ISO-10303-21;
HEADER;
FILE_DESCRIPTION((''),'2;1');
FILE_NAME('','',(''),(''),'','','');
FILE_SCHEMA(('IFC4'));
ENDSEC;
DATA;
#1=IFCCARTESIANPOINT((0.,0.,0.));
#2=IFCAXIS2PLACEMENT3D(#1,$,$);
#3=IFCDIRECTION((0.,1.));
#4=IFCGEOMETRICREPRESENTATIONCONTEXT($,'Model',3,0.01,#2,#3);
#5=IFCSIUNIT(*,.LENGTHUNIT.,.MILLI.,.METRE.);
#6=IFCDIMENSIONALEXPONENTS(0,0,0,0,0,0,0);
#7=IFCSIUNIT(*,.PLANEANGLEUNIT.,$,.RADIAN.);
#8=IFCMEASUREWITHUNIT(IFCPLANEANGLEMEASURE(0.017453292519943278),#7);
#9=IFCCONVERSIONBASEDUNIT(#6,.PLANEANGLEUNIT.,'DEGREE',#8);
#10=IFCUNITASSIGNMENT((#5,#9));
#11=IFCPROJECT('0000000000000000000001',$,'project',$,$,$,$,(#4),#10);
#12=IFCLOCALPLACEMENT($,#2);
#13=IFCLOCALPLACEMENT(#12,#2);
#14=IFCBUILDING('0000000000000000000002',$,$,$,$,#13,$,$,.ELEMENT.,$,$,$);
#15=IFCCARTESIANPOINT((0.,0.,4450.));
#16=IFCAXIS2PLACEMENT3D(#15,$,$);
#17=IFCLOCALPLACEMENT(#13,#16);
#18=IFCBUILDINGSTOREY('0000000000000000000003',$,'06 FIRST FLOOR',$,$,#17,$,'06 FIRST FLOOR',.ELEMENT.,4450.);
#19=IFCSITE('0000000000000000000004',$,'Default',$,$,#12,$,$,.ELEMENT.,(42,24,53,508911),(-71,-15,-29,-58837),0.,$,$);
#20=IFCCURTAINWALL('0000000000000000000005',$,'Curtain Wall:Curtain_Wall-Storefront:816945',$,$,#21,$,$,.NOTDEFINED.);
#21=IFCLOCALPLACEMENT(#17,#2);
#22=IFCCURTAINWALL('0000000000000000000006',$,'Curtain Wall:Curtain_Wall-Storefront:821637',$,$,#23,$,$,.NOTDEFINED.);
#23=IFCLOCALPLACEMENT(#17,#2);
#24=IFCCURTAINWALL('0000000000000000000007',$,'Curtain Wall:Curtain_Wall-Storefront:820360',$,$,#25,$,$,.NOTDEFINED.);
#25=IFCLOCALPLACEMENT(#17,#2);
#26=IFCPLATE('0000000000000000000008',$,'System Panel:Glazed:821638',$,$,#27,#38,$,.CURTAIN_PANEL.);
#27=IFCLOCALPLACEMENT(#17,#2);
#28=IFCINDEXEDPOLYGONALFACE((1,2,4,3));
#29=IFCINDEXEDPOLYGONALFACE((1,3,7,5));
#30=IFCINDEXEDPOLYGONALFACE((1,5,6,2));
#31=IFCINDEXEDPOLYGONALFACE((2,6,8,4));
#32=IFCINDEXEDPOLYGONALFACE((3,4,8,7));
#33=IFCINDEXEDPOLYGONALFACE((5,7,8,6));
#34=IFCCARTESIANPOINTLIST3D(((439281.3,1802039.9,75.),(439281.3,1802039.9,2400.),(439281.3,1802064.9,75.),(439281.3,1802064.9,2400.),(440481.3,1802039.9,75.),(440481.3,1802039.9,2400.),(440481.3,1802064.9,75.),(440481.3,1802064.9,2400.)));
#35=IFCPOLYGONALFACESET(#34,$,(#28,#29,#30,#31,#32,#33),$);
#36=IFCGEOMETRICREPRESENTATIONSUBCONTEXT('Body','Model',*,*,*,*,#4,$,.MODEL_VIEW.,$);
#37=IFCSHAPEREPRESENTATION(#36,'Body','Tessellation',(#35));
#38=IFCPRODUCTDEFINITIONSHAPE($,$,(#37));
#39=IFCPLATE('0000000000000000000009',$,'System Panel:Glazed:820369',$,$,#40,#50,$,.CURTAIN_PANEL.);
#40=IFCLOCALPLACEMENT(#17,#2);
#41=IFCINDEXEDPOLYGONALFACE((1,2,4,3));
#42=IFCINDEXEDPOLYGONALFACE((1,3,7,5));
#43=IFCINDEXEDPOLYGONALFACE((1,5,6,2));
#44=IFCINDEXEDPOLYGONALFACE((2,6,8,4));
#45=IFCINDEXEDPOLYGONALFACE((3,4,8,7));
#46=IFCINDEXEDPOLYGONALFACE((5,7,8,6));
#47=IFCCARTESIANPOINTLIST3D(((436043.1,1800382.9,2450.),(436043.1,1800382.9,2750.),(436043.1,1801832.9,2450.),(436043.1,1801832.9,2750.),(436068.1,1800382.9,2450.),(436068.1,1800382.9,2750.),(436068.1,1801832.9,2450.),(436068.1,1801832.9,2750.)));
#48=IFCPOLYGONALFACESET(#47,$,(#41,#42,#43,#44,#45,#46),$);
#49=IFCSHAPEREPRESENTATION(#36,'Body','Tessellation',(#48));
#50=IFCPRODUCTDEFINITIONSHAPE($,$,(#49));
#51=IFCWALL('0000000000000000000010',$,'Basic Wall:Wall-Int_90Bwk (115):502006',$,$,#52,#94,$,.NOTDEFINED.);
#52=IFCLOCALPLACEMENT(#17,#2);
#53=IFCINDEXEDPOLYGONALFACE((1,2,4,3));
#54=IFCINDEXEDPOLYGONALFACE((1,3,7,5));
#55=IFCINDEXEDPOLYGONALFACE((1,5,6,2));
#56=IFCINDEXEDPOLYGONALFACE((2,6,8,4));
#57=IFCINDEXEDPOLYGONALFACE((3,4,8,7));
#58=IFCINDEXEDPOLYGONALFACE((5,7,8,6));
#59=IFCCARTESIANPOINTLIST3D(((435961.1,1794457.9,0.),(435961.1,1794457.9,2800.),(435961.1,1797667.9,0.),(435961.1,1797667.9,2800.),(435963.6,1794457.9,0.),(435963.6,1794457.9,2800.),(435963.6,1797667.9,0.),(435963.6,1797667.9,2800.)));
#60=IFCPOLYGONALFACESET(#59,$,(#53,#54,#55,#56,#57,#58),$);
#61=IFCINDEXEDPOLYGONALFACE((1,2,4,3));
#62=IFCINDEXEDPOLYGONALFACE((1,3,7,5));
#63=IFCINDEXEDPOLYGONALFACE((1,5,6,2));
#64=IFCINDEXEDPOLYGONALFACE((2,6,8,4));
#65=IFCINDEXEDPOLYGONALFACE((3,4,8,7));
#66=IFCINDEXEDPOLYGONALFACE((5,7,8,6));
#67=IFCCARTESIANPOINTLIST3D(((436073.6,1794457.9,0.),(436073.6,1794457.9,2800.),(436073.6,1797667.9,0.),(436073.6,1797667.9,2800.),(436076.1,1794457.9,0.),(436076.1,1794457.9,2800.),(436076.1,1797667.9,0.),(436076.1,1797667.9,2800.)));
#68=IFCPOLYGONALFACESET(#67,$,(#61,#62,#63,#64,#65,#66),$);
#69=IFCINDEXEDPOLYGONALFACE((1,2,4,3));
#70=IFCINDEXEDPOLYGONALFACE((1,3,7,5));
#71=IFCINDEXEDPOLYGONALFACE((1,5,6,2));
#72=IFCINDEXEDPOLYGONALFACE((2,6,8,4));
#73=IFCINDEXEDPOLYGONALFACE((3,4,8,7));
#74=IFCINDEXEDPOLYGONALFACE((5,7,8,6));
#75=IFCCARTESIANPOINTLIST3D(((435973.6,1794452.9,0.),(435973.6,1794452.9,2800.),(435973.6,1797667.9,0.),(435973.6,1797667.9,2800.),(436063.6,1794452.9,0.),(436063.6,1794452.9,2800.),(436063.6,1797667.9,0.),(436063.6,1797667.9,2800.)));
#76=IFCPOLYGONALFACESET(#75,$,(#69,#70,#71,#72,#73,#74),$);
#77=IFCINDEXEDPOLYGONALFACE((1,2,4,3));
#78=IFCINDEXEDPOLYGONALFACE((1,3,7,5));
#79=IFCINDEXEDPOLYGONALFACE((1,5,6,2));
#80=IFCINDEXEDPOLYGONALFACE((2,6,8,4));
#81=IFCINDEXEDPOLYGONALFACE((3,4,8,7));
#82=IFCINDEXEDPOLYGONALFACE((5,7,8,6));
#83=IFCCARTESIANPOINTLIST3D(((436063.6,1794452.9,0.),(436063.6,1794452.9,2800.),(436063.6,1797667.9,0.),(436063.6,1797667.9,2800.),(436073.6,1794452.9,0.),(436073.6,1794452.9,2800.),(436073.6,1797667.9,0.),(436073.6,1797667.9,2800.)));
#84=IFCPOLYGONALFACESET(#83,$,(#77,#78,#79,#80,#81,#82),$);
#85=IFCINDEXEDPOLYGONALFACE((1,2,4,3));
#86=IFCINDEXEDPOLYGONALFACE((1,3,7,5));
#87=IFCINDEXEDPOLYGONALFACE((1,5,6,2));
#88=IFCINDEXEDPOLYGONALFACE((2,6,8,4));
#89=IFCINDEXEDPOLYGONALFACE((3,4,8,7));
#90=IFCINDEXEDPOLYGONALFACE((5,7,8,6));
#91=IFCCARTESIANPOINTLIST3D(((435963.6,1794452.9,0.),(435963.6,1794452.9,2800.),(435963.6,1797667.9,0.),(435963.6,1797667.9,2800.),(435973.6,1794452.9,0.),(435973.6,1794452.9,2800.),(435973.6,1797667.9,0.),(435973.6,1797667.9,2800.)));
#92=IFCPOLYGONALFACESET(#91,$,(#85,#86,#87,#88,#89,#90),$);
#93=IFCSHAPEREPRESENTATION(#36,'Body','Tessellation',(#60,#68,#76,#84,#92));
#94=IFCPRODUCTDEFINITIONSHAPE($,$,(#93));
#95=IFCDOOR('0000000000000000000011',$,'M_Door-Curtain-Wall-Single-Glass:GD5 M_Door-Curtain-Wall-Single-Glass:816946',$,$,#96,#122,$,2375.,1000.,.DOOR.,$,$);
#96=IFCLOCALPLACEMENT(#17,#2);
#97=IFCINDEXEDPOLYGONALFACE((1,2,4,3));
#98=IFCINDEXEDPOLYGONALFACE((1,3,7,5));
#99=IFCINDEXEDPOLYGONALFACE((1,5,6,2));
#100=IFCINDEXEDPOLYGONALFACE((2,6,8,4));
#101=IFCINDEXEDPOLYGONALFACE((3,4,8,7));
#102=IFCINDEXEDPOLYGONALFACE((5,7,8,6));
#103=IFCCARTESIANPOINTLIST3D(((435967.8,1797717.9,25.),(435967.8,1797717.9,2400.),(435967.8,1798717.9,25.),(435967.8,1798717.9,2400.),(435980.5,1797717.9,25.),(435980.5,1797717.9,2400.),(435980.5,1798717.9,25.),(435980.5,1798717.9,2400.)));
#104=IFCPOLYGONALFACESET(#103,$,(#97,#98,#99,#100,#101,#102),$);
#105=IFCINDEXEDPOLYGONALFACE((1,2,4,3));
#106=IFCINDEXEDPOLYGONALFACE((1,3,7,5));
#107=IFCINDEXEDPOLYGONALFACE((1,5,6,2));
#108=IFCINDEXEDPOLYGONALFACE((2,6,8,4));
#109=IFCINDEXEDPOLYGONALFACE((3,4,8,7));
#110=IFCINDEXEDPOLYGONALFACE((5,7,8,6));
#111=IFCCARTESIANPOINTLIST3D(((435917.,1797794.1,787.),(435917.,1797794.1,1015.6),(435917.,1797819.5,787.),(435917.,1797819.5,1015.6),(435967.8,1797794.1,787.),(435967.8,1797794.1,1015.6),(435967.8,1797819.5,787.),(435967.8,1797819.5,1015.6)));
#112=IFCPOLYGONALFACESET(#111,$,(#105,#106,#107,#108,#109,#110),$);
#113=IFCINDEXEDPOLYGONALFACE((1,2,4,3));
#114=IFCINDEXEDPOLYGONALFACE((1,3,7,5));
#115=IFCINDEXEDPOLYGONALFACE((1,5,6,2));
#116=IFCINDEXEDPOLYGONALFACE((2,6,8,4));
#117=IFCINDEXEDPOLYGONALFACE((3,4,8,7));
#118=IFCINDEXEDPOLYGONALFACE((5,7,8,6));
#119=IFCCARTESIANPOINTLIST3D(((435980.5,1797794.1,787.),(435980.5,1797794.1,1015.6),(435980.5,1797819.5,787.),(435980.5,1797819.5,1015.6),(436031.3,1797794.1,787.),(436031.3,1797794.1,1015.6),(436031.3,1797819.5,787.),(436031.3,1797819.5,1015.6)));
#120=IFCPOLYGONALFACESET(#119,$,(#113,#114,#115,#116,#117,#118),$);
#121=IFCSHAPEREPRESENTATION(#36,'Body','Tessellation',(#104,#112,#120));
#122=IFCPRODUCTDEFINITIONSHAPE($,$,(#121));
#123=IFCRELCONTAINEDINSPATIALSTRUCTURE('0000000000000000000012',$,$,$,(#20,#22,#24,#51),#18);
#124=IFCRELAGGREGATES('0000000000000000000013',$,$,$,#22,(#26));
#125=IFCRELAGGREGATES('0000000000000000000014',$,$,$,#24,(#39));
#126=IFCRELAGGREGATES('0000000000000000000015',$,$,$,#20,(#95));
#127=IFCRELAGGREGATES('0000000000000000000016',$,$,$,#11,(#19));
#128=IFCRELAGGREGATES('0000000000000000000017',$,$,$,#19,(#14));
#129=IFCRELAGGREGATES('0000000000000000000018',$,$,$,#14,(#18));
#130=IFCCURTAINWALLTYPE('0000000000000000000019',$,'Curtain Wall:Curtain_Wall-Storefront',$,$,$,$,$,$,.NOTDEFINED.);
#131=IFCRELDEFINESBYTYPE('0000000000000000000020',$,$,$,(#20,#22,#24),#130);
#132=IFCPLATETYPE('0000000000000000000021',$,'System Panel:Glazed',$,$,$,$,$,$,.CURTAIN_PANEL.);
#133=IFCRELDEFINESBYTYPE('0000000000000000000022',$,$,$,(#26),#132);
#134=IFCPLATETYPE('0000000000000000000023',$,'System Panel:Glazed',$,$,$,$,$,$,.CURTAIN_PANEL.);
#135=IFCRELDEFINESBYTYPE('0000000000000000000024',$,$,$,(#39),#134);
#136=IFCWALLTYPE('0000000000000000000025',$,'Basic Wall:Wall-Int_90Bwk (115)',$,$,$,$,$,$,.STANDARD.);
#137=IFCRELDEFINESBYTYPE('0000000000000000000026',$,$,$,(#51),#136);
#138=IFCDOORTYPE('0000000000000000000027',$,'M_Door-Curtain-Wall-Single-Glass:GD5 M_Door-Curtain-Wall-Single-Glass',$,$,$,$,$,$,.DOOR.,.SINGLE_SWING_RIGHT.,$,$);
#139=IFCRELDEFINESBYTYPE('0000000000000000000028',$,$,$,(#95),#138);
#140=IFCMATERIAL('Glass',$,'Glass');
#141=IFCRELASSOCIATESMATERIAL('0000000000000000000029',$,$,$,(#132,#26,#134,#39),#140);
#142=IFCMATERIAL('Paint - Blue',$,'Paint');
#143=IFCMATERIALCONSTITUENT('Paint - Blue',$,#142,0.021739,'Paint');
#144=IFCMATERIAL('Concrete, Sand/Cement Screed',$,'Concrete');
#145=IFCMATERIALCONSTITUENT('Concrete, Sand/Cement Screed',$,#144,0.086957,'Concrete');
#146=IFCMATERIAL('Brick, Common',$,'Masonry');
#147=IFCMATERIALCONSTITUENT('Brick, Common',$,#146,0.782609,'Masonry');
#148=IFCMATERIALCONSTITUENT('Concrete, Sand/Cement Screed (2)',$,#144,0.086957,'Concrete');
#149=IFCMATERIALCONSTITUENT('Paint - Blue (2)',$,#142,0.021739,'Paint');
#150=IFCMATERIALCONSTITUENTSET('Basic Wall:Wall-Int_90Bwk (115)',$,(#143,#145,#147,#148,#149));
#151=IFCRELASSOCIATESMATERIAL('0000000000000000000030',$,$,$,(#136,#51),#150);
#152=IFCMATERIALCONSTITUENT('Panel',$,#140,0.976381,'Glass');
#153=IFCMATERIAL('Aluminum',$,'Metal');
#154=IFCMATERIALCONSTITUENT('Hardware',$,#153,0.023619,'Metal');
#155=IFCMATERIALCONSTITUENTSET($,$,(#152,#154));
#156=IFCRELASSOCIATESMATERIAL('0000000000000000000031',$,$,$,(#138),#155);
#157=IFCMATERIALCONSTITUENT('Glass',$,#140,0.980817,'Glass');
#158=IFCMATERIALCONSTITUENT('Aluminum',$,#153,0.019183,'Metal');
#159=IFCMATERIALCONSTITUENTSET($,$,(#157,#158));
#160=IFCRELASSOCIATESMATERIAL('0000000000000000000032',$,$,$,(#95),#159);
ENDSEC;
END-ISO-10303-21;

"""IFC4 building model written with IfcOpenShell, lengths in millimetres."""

from ifc_helpers import new_model, entity, si_unit, converted_unit, direction, frame, origin, place, context, subcontext, project, spatial, indexed_curve, outline, extrude, source, transform, mapped, material, constituent, constituent_set, type_object, type_shapes, element, aggregate, save


model = new_model("IFC4")

# Units and contexts
model_context = context("Model", 3, precision=0.01, world=origin(), true_north=direction((0.0, 1.0)))
body_context = subcontext(model_context, "Body", "Model", "MODEL_VIEW")
ifc_project = project(units=[si_unit("LENGTHUNIT", "METRE", prefix="MILLI"), converted_unit("PLANEANGLEUNIT", "DEGREE", entity("IfcPlaneAngleMeasure", 0.017453292519943278), si_unit("PLANEANGLEUNIT", "RADIAN"), dimensions=[0, 0, 0, 0, 0, 0, 0])], contexts=[model_context])

# Site, building, storey
site_placement = place(None, origin())
site = spatial("IfcSite", under=ifc_project, at=site_placement, Name="Default", CompositionType="ELEMENT", RefLatitude=(42, 24, 53, 508911), RefLongitude=(-71, -15, -29, -58837), RefElevation=0.0)
building_placement = place(site_placement, origin())
building = spatial("IfcBuilding", under=site, at=building_placement, CompositionType="ELEMENT")
storey_placement = place(building_placement, frame((0.0, 0.0, 4450.0)))
storey = spatial("IfcBuildingStorey", under=building, at=storey_placement, Name="06 FIRST FLOOR", LongName="06 FIRST FLOOR", CompositionType="ELEMENT", Elevation=4450.0)

# Curtain walls
curtain_wall_type = type_object("IfcCurtainWallType", Name="Curtain Wall:Curtain_Wall-Storefront", PredefinedType="NOTDEFINED")
curtain_wall_1_placement = place(storey_placement, frame((0.0, 0.0, -4450.0)))
curtain_wall_1 = element("IfcCurtainWall", 1, at=curtain_wall_1_placement, inside=storey, type_object=curtain_wall_type, Name="Curtain Wall:Curtain_Wall-Storefront:816945", PredefinedType="NOTDEFINED")
curtain_wall_2_placement = place(storey_placement, frame((0.0, 0.0, -4450.0)))
curtain_wall_2 = element("IfcCurtainWall", 2, at=curtain_wall_2_placement, inside=storey, type_object=curtain_wall_type, Name="Curtain Wall:Curtain_Wall-Storefront:821637", PredefinedType="NOTDEFINED")

# Curtain wall
curtain_wall_3_placement = place(storey_placement, frame((0.0, 0.0, -4450.0)))
curtain_wall_3 = element("IfcCurtainWall", 3, at=curtain_wall_3_placement, inside=storey, type_object=curtain_wall_type, Name="Curtain Wall:Curtain_Wall-Storefront:820360", PredefinedType="NOTDEFINED")

# Plates
ifc_material_1 = material(Name="Glass", Category="Glass")
plate_type_1 = type_object("IfcPlateType", Name="System Panel:Glazed", PredefinedType="CURTAIN_PANEL", material=ifc_material_1)
shared_shape_1 = source(origin(), body_context, "Body", "SweptSolid", [
    extrude(outline(indexed_curve([(-12.5, -600.0), (12.5, -600.0), (12.5, 600.0), (-12.5, 600.0), (-12.5, -600.0)], self_intersect=False)), frame((0.0, 37.0, 0.0), z_axis=(0.0, 0.0, 1.0), x_axis=(0.0, 1.0, 0.0)), (0.0, 0.0, 1.0), 2325.0),
])
type_shapes(plate_type_1, [shared_shape_1])
plate_1_placement = place(curtain_wall_2_placement, frame((439881.3, 1802015.4, 4525.0)))
plate_1 = element("IfcPlate", 4, at=plate_1_placement, type_object=plate_type_1, material=ifc_material_1, Name="System Panel:Glazed:821638", PredefinedType="CURTAIN_PANEL", context=body_context, shape_type="MappedRepresentation", body=[
    mapped(shared_shape_1, transform((0.0, 0.0, 0.0), scale=1.0)),
])
aggregate(curtain_wall_2, [plate_1])
plate_type_2 = type_object("IfcPlateType", Name="System Panel:Glazed", PredefinedType="CURTAIN_PANEL", material=ifc_material_1)
shared_shape_2 = source(origin(), body_context, "Body", "SweptSolid", [
    extrude(outline(indexed_curve([(-12.5, -725.0), (12.5, -725.0), (12.5, 725.0), (-12.5, 725.0), (-12.5, -725.0)], self_intersect=False)), frame((0.0, 37.0, 0.0), z_axis=(0.0, 0.0, 1.0), x_axis=(0.0, 1.0, 0.0)), (0.0, 0.0, 1.0), 300.0),
])
type_shapes(plate_type_2, [shared_shape_2])
plate_2_placement = place(curtain_wall_3_placement, frame((436018.6, 1801107.9, 6900.0), z_axis=(0.0, 0.0, 1.0), x_axis=(0.0, -1.0, 0.0)))
plate_2 = element("IfcPlate", 5, at=plate_2_placement, type_object=plate_type_2, material=ifc_material_1, Name="System Panel:Glazed:820369", PredefinedType="CURTAIN_PANEL", context=body_context, shape_type="MappedRepresentation", body=[
    mapped(shared_shape_2, transform((0.0, 0.0, 0.0), scale=1.0)),
])
aggregate(curtain_wall_3, [plate_2])

# Wall
ifc_material_2 = material(Name="Paint - Blue", Category="Paint")
ifc_constituent_1 = constituent(ifc_material_2, Name="Paint - Blue", Category="Paint", fraction=0.021739)
ifc_material_3 = material(Name="Concrete, Sand/Cement Screed", Category="Concrete")
ifc_constituent_2 = constituent(ifc_material_3, Name="Concrete, Sand/Cement Screed", Category="Concrete", fraction=0.086957)
ifc_material_4 = material(Name="Brick, Common", Category="Masonry")
ifc_constituent_3 = constituent(ifc_material_4, Name="Brick, Common", Category="Masonry", fraction=0.782609)
ifc_constituent_4 = constituent(ifc_material_3, Name="Concrete, Sand/Cement Screed (2)", Category="Concrete", fraction=0.086957)
ifc_constituent_5 = constituent(ifc_material_2, Name="Paint - Blue (2)", Category="Paint", fraction=0.021739)
ifc_constituent_set_1 = constituent_set(constituents=[ifc_constituent_1, ifc_constituent_2, ifc_constituent_3, ifc_constituent_4, ifc_constituent_5], Name="Basic Wall:Wall-Int_90Bwk (115)")
wall_type = type_object("IfcWallType", Name="Basic Wall:Wall-Int_90Bwk (115)", PredefinedType="STANDARD", material=ifc_constituent_set_1)
wall_placement = place(storey_placement, frame((436018.6, 1797667.9, 0.0), z_axis=(0.0, 0.0, 1.0), x_axis=(0.0, -1.0, 0.0)))
element("IfcWall", 6, at=wall_placement, inside=storey, type_object=wall_type, material=ifc_constituent_set_1, Name="Basic Wall:Wall-Int_90Bwk (115):502006", PredefinedType="NOTDEFINED", context=body_context, shape_type="SweptSolid", body=[
    extrude(outline(indexed_curve([(-1.2, -1605.0), (1.3, -1605.0), (1.3, 1605.0), (-1.2, 1605.0), (-1.2, -1605.0)], self_intersect=False)), frame((1605.0, -56.3, 0.0), z_axis=(0.0, 0.0, 1.0), x_axis=(0.0, 1.0, 0.0)), (0.0, 0.0, 1.0), 2800.0),
    extrude(outline(indexed_curve([(-1.2, -1605.0), (1.3, -1605.0), (1.3, 1605.0), (-1.2, 1605.0), (-1.2, -1605.0)], self_intersect=False)), frame((1605.0, 56.3, 0.0), z_axis=(0.0, 0.0, 1.0), x_axis=(0.0, -1.0, 0.0)), (0.0, 0.0, 1.0), 2800.0),
    extrude(outline(indexed_curve([(-1607.5, -45.0), (1607.5, -45.0), (1607.5, 45.0), (-1607.5, 45.0), (-1607.5, -45.0)], self_intersect=False)), frame((1607.5, 0.0, 0.0)), (0.0, 0.0, 1.0), 2800.0),
    extrude(outline(indexed_curve([(-1607.5, -5.0), (1607.5, -5.0), (1607.5, 5.0), (-1607.5, 5.0), (-1607.5, -5.0)], self_intersect=False)), frame((1607.5, 50.0, 0.0)), (0.0, 0.0, 1.0), 2800.0),
    extrude(outline(indexed_curve([(-1607.5, -5.0), (1607.5, -5.0), (1607.5, 5.0), (-1607.5, 5.0), (-1607.5, -5.0)], self_intersect=False)), frame((1607.5, -50.0, 0.0)), (0.0, 0.0, 1.0), 2800.0),
])

# Door
ifc_constituent_6 = constituent(ifc_material_1, Name="Glass", Category="Glass", fraction=0.980817)
ifc_material_5 = material(Name="Aluminum", Category="Metal")
ifc_constituent_7 = constituent(ifc_material_5, Name="Aluminum", Category="Metal", fraction=0.019183)
ifc_constituent_set_2 = constituent_set(constituents=[ifc_constituent_6, ifc_constituent_7])
ifc_constituent_8 = constituent(ifc_material_1, Name="Panel", Category="Glass", fraction=0.976381)
ifc_constituent_9 = constituent(ifc_material_5, Name="Hardware", Category="Metal", fraction=0.023619)
ifc_constituent_set_3 = constituent_set(constituents=[ifc_constituent_8, ifc_constituent_9])
door_type = type_object("IfcDoorType", Name="M_Door-Curtain-Wall-Single-Glass:GD5 M_Door-Curtain-Wall-Single-Glass", OperationType="SINGLE_SWING_RIGHT", PredefinedType="DOOR", material=ifc_constituent_set_3)
shared_shape_3 = source(origin(), body_context, "Body", "SweptSolid", [
    extrude(outline(indexed_curve([(-500.0, -6.4), (500.0, -6.4), (500.0, 6.4), (-500.0, 6.4), (-500.0, -6.4)], self_intersect=False)), frame((0.0, 44.5, 0.0), z_axis=(0.0, 0.0, 1.0), x_axis=(-1.0, 0.0, 0.0)), (0.0, 0.0, 1.0), 2375.0),
    extrude(outline(indexed_curve([(-25.4, -12.7), (25.4, -12.7), (25.4, 12.7), (-25.4, 12.7), (-25.4, -12.7)], self_intersect=False)), frame((-411.1, 76.2, 762.0), z_axis=(0.0, 0.0, 1.0), x_axis=(0.0, -1.0, 0.0)), (0.0, 0.0, 1.0), 228.6),
    extrude(outline(indexed_curve([(-25.4, -12.7), (25.4, -12.7), (25.4, 12.7), (-25.4, 12.7), (-25.4, -12.7)], self_intersect=False)), frame((-411.1, 12.7, 762.0), z_axis=(0.0, 0.0, 1.0), x_axis=(0.0, 1.0, 0.0)), (0.0, 0.0, 1.0), 228.6),
])
type_shapes(door_type, [shared_shape_3])
door_placement = place(curtain_wall_1_placement, frame((436018.6, 1798217.9, 4475.0), z_axis=(0.0, 0.0, 1.0), x_axis=(0.0, 1.0, 0.0)))
door = element("IfcDoor", 7, at=door_placement, type_object=door_type, material=ifc_constituent_set_2, Name="M_Door-Curtain-Wall-Single-Glass:GD5 M_Door-Curtain-Wall-Single-Glass:816946", OverallHeight=2375.0, OverallWidth=1000.0, PredefinedType="DOOR", context=body_context, shape_type="MappedRepresentation", body=[
    mapped(shared_shape_3, transform((0.0, 0.0, 0.0), scale=1.0)),
])
aggregate(curtain_wall_1, [door])

save(model, "model.ifc")
